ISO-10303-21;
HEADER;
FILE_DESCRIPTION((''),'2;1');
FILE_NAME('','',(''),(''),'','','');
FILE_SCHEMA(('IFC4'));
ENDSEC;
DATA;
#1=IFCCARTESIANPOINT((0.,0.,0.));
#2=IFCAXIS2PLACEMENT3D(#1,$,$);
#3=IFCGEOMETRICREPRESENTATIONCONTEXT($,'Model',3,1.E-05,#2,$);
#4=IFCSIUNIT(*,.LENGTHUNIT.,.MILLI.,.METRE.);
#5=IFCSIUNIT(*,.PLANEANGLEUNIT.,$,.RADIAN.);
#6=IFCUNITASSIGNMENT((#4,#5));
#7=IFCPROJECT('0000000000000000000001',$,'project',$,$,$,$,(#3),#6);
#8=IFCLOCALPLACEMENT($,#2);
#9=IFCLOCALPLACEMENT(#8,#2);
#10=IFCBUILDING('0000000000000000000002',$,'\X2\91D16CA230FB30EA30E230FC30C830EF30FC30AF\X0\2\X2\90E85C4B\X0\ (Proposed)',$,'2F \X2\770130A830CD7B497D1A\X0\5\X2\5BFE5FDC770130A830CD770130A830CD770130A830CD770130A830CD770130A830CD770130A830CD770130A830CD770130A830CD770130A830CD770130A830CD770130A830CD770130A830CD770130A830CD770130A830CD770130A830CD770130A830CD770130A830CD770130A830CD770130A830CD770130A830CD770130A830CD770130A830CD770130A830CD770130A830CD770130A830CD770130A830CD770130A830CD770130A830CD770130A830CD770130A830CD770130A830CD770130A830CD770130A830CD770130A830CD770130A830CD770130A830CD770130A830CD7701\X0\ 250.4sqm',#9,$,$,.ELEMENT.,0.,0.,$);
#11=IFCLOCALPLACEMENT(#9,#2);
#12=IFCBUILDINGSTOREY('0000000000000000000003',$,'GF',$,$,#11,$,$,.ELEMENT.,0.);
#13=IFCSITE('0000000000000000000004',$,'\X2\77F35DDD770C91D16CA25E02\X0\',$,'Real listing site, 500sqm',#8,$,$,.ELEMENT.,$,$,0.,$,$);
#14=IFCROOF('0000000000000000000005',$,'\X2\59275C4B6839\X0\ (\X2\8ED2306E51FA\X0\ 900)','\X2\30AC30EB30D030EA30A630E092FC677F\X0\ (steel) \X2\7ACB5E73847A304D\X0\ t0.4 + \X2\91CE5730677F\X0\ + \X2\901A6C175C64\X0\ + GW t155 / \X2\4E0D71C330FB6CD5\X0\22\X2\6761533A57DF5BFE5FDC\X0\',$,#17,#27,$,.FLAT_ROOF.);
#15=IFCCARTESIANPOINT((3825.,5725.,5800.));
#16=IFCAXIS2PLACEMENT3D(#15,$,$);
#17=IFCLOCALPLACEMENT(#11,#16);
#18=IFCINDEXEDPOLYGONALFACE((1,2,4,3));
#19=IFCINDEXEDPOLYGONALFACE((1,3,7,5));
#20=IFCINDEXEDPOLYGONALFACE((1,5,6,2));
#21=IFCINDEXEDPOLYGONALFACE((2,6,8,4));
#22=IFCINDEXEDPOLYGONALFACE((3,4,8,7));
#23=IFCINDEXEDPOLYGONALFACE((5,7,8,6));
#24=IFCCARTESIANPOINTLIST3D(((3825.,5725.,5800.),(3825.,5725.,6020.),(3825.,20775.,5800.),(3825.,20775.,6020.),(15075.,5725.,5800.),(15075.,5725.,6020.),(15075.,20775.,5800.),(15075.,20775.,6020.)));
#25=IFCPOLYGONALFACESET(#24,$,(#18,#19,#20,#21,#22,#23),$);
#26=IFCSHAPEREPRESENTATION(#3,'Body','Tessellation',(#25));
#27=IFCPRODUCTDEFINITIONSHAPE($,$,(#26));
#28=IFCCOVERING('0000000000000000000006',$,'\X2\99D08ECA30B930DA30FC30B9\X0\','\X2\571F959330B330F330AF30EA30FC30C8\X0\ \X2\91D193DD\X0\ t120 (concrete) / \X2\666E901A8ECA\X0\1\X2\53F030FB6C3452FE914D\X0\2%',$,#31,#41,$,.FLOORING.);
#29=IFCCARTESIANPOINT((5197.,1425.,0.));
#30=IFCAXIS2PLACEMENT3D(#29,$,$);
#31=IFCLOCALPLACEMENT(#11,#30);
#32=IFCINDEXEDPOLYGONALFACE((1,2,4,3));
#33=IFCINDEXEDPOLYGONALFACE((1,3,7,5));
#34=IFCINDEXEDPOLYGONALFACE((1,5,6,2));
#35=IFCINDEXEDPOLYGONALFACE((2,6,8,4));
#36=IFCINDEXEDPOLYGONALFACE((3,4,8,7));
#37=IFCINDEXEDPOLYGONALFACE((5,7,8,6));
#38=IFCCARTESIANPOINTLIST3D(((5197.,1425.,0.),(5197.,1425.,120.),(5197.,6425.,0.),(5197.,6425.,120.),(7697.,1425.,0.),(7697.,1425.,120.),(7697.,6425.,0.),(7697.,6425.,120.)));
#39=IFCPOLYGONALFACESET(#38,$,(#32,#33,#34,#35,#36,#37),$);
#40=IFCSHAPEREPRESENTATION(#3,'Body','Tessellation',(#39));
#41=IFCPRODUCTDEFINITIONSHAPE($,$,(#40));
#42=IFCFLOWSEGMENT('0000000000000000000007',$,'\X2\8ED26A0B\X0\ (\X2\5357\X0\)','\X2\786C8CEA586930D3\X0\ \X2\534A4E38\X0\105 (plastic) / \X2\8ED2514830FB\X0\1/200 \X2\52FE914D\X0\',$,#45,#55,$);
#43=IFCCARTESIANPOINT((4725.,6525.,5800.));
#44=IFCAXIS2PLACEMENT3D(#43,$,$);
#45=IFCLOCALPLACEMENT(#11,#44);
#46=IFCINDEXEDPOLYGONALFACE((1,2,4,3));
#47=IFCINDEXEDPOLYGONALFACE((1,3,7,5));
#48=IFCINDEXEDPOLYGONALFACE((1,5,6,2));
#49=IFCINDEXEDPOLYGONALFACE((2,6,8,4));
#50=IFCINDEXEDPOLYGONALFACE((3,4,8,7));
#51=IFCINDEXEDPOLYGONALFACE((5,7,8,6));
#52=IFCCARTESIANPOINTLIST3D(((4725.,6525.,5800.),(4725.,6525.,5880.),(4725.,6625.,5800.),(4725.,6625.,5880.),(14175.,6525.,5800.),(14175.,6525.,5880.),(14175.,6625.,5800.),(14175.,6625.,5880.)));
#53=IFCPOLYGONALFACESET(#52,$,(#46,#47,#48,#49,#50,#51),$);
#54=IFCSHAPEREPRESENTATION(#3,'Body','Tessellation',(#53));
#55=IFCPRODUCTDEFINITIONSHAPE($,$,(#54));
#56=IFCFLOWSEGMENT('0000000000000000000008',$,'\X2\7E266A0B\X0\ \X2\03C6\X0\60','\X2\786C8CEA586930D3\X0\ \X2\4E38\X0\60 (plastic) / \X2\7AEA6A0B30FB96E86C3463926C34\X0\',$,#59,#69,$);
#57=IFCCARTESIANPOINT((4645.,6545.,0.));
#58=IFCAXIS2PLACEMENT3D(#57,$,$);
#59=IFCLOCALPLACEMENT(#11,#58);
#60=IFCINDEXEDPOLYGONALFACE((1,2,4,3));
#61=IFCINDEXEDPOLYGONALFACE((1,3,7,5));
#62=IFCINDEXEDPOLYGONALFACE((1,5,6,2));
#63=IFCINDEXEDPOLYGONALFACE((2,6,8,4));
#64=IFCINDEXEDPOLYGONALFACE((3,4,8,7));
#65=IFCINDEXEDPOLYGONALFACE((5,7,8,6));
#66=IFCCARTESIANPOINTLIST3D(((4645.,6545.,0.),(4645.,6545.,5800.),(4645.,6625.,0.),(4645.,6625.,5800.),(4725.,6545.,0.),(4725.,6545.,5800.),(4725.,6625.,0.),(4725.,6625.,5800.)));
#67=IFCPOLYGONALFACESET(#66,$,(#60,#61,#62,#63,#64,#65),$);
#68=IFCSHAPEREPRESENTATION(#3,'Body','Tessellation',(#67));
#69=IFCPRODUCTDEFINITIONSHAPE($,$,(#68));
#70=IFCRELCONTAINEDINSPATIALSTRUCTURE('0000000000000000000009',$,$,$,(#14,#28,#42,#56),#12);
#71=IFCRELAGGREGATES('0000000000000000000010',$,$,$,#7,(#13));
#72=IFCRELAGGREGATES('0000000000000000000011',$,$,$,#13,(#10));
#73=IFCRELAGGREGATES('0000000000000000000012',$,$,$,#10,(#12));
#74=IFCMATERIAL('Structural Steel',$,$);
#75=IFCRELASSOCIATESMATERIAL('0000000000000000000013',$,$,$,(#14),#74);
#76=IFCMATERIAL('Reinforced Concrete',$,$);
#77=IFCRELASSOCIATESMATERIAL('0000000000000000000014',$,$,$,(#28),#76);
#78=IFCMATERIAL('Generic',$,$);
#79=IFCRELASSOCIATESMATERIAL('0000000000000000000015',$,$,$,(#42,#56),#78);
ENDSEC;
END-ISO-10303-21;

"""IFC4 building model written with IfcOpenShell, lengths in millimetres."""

from ifc_helpers import new_model, si_unit, frame, frame_2d, origin, place, context, project, spatial, rectangle, extrude, material, element, save


model = new_model("IFC4")

# Units and contexts
model_context = context("Model", 3, precision=1e-05, world=origin())
ifc_project = project(units=[si_unit("LENGTHUNIT", "METRE", prefix="MILLI"), si_unit("PLANEANGLEUNIT", "RADIAN")], contexts=[model_context])

# Site, building, storey
site_placement = place(None, origin())
site = spatial("IfcSite", under=ifc_project, at=site_placement, Name="石川県金沢市", ObjectType="Real listing site, 500sqm", CompositionType="ELEMENT", RefElevation=0.0)
building_placement = place(site_placement, origin())
building = spatial("IfcBuilding", under=site, at=building_placement, Name="金沢・リモートワーク2部屋 (Proposed)", ObjectType="2F 省エネ等級5対応省エネ省エネ省エネ省エネ省エネ省エネ省エネ省エネ省エネ省エネ省エネ省エネ省エネ省エネ省エネ省エネ省エネ省エネ省エネ省エネ省エネ省エネ省エネ省エネ省エネ省エネ省エネ省エネ省エネ省エネ省エネ省エネ省エネ省エネ省エネ省エネ省エネ省 250.4sqm", CompositionType="ELEMENT", ElevationOfRefHeight=0.0, ElevationOfTerrain=0.0)
storey_placement = place(building_placement, origin())
storey = spatial("IfcBuildingStorey", under=building, at=storey_placement, Name="GF", CompositionType="ELEMENT", Elevation=0.0)

# Shared definitions
ifc_material_1 = material(Name="Reinforced Concrete")

# Roof
ifc_material_2 = material(Name="Structural Steel")
roof_placement = place(storey_placement, frame((3825.0, 5725.0, 5800.0)))
element("IfcRoof", 1, at=roof_placement, inside=storey, material=ifc_material_2, Name="大屋根 (軒の出 900)", Description="ガルバリウム鋼板 (steel) 立平葺き t0.4 + 野地板 + 通気層 + GW t155 / 不燃・法22条区域対応", PredefinedType="FLAT_ROOF", context=model_context, shape_type="SweptSolid", body=[
    extrude(rectangle(XDim=11250.0, YDim=15050.0, at=frame_2d((5625.0, 7525.0))), frame((3825.0, 5725.0, 5800.0)), (0.0, 0.0, 1.0), 220.0),
])

# Covering
covering_placement = place(storey_placement, frame((5197.0, 1425.0, 0.0)))
element("IfcCovering", 2, at=covering_placement, inside=storey, material=ifc_material_1, Name="駐車スペース", Description="土間コンクリート 金鏝 t120 (concrete) / 普通車1台・水勾配2%", PredefinedType="FLOORING", context=model_context, shape_type="SweptSolid", body=[
    extrude(rectangle(XDim=2500.0, YDim=5000.0, at=frame_2d((1250.0, 2500.0))), frame((5197.0, 1425.0, 0.0)), (0.0, 0.0, 1.0), 120.0),
])

# Flow segments
ifc_material_3 = material(Name="Generic")
flow_segment_1_placement = place(storey_placement, frame((4725.0, 6525.0, 5800.0)))
element("IfcFlowSegment", 3, at=flow_segment_1_placement, inside=storey, material=ifc_material_3, Name="軒樋 (南)", Description="硬質塩ビ 半丸105 (plastic) / 軒先・1/200 勾配", context=model_context, shape_type="SweptSolid", body=[
    extrude(rectangle(XDim=9450.0, YDim=100.0, at=frame_2d((4725.0, 50.0))), frame((4725.0, 6525.0, 5800.0)), (0.0, 0.0, 1.0), 80.0),
])
flow_segment_2_placement = place(storey_placement, frame((4645.0, 6545.0, 0.0)))
element("IfcFlowSegment", 4, at=flow_segment_2_placement, inside=storey, material=ifc_material_3, Name="縦樋 φ60", Description="硬質塩ビ 丸60 (plastic) / 竪樋・雨水排水", context=model_context, shape_type="SweptSolid", body=[
    extrude(rectangle(XDim=80.0, YDim=80.0, at=frame_2d((40.0, 40.0))), frame((4645.0, 6545.0, 0.0)), (0.0, 0.0, 1.0), 5800.0),
])

save(model, "model.ifc")
